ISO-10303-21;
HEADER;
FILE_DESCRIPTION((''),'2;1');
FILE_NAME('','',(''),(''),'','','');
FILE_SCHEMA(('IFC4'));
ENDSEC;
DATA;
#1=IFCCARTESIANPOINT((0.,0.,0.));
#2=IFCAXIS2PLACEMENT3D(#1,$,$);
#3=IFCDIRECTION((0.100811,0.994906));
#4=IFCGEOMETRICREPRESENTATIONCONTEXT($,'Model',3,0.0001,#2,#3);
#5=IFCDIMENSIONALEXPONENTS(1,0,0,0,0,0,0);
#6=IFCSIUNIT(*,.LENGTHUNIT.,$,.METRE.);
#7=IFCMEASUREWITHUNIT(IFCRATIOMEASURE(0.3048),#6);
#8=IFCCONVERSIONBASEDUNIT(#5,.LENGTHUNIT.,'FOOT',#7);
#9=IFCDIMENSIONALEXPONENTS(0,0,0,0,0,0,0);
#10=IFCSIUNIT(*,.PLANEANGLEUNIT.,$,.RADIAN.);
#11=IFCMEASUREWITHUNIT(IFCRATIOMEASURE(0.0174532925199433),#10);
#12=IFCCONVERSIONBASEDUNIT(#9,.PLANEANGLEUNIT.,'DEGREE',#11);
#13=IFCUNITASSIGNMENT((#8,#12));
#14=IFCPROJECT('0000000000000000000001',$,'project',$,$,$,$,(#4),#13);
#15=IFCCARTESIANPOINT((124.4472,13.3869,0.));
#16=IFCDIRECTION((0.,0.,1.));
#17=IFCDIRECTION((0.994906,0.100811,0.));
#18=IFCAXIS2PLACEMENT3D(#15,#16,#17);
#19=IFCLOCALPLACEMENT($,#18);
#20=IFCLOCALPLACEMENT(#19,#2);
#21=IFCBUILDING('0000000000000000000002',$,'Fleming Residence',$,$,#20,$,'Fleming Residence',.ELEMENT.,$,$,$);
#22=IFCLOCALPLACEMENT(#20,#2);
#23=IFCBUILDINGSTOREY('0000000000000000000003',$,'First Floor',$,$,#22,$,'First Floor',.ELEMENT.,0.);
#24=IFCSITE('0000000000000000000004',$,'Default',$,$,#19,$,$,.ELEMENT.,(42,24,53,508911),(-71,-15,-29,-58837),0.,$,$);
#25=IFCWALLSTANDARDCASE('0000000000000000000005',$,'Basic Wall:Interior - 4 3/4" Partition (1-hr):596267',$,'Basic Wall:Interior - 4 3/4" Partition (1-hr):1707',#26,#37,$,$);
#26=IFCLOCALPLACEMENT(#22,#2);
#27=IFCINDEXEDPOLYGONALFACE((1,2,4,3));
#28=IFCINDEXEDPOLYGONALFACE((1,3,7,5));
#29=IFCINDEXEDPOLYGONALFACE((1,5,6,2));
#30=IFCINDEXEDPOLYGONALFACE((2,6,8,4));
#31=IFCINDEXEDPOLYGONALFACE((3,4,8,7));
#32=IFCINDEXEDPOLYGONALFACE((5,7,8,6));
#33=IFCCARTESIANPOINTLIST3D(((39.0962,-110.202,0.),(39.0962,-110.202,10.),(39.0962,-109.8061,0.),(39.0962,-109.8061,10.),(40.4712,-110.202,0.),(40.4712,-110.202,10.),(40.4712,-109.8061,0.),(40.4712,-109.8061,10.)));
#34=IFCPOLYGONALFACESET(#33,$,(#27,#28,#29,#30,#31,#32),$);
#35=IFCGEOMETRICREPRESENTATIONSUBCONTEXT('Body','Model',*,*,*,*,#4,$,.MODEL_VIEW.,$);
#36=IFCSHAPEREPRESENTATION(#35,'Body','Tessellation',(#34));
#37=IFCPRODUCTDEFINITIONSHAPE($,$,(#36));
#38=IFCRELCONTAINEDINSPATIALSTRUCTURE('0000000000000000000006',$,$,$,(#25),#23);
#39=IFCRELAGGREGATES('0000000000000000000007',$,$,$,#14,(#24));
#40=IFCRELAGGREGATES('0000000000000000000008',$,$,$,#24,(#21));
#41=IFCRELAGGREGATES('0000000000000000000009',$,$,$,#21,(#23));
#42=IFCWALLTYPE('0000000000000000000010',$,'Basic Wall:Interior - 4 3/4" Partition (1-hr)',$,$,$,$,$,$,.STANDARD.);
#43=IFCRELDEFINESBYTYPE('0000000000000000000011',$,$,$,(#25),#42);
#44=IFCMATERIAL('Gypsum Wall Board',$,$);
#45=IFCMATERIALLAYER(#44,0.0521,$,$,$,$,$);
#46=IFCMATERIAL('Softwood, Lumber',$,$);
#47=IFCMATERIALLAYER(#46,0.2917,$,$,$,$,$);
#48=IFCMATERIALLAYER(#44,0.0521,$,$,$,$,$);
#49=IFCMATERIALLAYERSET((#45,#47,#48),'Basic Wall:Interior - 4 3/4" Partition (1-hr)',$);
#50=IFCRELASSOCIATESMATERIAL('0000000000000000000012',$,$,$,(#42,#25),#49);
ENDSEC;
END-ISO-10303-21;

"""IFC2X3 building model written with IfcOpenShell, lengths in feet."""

from ifc_helpers import new_model, entity, si_unit, converted_unit, direction, frame, frame_2d, origin, place, context, subcontext, project, spatial, rectangle, extrude, material, layer, layer_set, layer_usage, type_object, element, save


model = new_model("IFC2X3")

# Units and contexts
model_context = context("Model", 3, precision=0.0001, world=origin(), true_north=direction((0.100811, 0.994906)))
body_context = subcontext(model_context, "Body", "Model", "MODEL_VIEW")
ifc_project = project(units=[converted_unit("LENGTHUNIT", "FOOT", entity("IfcRatioMeasure", 0.3048), si_unit("LENGTHUNIT", "METRE"), dimensions=[1, 0, 0, 0, 0, 0, 0]), converted_unit("PLANEANGLEUNIT", "DEGREE", entity("IfcRatioMeasure", 0.0174532925199433), si_unit("PLANEANGLEUNIT", "RADIAN"), dimensions=[0, 0, 0, 0, 0, 0, 0])], contexts=[model_context])

# Site, building, storey
site_placement = place(None, frame((124.4472, 13.3869, 0.0), z_axis=(0.0, 0.0, 1.0), x_axis=(0.994906, 0.100811, 0.0)))
site = spatial("IfcSite", under=ifc_project, at=site_placement, Name="Default", CompositionType="ELEMENT", RefLatitude=(42, 24, 53, 508911), RefLongitude=(-71, -15, -29, -58837), RefElevation=0.0)
building_placement = place(site_placement, origin())
building = spatial("IfcBuilding", under=site, at=building_placement, Name="Fleming Residence", LongName="Fleming Residence", CompositionType="ELEMENT")
storey_placement = place(building_placement, origin())
storey = spatial("IfcBuildingStorey", under=building, at=storey_placement, Name="First Floor", LongName="First Floor", CompositionType="ELEMENT", Elevation=0.0)

# Wall
ifc_material_1 = material(Name="Softwood, Lumber")
ifc_material_2 = material(Name="Gypsum Wall Board")
ifc_layer_1 = layer(ifc_material_2, 0.0521)
ifc_layer_2 = layer(ifc_material_1, 0.2917)
ifc_layer_3 = layer(ifc_material_2, 0.0521)
ifc_layer_set_1 = layer_set([ifc_layer_1, ifc_layer_2, ifc_layer_3], Name="Basic Wall:Interior - 4 3/4\" Partition (1-hr)")
wall_type_1 = type_object("IfcWallType", Name="Basic Wall:Interior - 4 3/4\" Partition (1-hr)", PredefinedType="STANDARD", material=ifc_layer_set_1)
ifc_layer_usage_1 = layer_usage(ifc_layer_set_1, "AXIS2", "NEGATIVE", 0.1979)
wall_1_placement = place(storey_placement, frame((39.0962, -110.0041, 0.0)))
element("IfcWallStandardCase", 1, at=wall_1_placement, inside=storey, type_object=wall_type_1, material=ifc_layer_usage_1, Name="Basic Wall:Interior - 4 3/4\" Partition (1-hr):596267", ObjectType="Basic Wall:Interior - 4 3/4\" Partition (1-hr):1707", context=body_context, shape_type="SweptSolid", body=[
    extrude(rectangle(XDim=1.375, YDim=0.3958, at=frame_2d((0.6875, 0.0), x_axis=(-1.0, 0.0))), origin(), (0.0, 0.0, 1.0), 10.0),
])

save(model, "model.ifc")
